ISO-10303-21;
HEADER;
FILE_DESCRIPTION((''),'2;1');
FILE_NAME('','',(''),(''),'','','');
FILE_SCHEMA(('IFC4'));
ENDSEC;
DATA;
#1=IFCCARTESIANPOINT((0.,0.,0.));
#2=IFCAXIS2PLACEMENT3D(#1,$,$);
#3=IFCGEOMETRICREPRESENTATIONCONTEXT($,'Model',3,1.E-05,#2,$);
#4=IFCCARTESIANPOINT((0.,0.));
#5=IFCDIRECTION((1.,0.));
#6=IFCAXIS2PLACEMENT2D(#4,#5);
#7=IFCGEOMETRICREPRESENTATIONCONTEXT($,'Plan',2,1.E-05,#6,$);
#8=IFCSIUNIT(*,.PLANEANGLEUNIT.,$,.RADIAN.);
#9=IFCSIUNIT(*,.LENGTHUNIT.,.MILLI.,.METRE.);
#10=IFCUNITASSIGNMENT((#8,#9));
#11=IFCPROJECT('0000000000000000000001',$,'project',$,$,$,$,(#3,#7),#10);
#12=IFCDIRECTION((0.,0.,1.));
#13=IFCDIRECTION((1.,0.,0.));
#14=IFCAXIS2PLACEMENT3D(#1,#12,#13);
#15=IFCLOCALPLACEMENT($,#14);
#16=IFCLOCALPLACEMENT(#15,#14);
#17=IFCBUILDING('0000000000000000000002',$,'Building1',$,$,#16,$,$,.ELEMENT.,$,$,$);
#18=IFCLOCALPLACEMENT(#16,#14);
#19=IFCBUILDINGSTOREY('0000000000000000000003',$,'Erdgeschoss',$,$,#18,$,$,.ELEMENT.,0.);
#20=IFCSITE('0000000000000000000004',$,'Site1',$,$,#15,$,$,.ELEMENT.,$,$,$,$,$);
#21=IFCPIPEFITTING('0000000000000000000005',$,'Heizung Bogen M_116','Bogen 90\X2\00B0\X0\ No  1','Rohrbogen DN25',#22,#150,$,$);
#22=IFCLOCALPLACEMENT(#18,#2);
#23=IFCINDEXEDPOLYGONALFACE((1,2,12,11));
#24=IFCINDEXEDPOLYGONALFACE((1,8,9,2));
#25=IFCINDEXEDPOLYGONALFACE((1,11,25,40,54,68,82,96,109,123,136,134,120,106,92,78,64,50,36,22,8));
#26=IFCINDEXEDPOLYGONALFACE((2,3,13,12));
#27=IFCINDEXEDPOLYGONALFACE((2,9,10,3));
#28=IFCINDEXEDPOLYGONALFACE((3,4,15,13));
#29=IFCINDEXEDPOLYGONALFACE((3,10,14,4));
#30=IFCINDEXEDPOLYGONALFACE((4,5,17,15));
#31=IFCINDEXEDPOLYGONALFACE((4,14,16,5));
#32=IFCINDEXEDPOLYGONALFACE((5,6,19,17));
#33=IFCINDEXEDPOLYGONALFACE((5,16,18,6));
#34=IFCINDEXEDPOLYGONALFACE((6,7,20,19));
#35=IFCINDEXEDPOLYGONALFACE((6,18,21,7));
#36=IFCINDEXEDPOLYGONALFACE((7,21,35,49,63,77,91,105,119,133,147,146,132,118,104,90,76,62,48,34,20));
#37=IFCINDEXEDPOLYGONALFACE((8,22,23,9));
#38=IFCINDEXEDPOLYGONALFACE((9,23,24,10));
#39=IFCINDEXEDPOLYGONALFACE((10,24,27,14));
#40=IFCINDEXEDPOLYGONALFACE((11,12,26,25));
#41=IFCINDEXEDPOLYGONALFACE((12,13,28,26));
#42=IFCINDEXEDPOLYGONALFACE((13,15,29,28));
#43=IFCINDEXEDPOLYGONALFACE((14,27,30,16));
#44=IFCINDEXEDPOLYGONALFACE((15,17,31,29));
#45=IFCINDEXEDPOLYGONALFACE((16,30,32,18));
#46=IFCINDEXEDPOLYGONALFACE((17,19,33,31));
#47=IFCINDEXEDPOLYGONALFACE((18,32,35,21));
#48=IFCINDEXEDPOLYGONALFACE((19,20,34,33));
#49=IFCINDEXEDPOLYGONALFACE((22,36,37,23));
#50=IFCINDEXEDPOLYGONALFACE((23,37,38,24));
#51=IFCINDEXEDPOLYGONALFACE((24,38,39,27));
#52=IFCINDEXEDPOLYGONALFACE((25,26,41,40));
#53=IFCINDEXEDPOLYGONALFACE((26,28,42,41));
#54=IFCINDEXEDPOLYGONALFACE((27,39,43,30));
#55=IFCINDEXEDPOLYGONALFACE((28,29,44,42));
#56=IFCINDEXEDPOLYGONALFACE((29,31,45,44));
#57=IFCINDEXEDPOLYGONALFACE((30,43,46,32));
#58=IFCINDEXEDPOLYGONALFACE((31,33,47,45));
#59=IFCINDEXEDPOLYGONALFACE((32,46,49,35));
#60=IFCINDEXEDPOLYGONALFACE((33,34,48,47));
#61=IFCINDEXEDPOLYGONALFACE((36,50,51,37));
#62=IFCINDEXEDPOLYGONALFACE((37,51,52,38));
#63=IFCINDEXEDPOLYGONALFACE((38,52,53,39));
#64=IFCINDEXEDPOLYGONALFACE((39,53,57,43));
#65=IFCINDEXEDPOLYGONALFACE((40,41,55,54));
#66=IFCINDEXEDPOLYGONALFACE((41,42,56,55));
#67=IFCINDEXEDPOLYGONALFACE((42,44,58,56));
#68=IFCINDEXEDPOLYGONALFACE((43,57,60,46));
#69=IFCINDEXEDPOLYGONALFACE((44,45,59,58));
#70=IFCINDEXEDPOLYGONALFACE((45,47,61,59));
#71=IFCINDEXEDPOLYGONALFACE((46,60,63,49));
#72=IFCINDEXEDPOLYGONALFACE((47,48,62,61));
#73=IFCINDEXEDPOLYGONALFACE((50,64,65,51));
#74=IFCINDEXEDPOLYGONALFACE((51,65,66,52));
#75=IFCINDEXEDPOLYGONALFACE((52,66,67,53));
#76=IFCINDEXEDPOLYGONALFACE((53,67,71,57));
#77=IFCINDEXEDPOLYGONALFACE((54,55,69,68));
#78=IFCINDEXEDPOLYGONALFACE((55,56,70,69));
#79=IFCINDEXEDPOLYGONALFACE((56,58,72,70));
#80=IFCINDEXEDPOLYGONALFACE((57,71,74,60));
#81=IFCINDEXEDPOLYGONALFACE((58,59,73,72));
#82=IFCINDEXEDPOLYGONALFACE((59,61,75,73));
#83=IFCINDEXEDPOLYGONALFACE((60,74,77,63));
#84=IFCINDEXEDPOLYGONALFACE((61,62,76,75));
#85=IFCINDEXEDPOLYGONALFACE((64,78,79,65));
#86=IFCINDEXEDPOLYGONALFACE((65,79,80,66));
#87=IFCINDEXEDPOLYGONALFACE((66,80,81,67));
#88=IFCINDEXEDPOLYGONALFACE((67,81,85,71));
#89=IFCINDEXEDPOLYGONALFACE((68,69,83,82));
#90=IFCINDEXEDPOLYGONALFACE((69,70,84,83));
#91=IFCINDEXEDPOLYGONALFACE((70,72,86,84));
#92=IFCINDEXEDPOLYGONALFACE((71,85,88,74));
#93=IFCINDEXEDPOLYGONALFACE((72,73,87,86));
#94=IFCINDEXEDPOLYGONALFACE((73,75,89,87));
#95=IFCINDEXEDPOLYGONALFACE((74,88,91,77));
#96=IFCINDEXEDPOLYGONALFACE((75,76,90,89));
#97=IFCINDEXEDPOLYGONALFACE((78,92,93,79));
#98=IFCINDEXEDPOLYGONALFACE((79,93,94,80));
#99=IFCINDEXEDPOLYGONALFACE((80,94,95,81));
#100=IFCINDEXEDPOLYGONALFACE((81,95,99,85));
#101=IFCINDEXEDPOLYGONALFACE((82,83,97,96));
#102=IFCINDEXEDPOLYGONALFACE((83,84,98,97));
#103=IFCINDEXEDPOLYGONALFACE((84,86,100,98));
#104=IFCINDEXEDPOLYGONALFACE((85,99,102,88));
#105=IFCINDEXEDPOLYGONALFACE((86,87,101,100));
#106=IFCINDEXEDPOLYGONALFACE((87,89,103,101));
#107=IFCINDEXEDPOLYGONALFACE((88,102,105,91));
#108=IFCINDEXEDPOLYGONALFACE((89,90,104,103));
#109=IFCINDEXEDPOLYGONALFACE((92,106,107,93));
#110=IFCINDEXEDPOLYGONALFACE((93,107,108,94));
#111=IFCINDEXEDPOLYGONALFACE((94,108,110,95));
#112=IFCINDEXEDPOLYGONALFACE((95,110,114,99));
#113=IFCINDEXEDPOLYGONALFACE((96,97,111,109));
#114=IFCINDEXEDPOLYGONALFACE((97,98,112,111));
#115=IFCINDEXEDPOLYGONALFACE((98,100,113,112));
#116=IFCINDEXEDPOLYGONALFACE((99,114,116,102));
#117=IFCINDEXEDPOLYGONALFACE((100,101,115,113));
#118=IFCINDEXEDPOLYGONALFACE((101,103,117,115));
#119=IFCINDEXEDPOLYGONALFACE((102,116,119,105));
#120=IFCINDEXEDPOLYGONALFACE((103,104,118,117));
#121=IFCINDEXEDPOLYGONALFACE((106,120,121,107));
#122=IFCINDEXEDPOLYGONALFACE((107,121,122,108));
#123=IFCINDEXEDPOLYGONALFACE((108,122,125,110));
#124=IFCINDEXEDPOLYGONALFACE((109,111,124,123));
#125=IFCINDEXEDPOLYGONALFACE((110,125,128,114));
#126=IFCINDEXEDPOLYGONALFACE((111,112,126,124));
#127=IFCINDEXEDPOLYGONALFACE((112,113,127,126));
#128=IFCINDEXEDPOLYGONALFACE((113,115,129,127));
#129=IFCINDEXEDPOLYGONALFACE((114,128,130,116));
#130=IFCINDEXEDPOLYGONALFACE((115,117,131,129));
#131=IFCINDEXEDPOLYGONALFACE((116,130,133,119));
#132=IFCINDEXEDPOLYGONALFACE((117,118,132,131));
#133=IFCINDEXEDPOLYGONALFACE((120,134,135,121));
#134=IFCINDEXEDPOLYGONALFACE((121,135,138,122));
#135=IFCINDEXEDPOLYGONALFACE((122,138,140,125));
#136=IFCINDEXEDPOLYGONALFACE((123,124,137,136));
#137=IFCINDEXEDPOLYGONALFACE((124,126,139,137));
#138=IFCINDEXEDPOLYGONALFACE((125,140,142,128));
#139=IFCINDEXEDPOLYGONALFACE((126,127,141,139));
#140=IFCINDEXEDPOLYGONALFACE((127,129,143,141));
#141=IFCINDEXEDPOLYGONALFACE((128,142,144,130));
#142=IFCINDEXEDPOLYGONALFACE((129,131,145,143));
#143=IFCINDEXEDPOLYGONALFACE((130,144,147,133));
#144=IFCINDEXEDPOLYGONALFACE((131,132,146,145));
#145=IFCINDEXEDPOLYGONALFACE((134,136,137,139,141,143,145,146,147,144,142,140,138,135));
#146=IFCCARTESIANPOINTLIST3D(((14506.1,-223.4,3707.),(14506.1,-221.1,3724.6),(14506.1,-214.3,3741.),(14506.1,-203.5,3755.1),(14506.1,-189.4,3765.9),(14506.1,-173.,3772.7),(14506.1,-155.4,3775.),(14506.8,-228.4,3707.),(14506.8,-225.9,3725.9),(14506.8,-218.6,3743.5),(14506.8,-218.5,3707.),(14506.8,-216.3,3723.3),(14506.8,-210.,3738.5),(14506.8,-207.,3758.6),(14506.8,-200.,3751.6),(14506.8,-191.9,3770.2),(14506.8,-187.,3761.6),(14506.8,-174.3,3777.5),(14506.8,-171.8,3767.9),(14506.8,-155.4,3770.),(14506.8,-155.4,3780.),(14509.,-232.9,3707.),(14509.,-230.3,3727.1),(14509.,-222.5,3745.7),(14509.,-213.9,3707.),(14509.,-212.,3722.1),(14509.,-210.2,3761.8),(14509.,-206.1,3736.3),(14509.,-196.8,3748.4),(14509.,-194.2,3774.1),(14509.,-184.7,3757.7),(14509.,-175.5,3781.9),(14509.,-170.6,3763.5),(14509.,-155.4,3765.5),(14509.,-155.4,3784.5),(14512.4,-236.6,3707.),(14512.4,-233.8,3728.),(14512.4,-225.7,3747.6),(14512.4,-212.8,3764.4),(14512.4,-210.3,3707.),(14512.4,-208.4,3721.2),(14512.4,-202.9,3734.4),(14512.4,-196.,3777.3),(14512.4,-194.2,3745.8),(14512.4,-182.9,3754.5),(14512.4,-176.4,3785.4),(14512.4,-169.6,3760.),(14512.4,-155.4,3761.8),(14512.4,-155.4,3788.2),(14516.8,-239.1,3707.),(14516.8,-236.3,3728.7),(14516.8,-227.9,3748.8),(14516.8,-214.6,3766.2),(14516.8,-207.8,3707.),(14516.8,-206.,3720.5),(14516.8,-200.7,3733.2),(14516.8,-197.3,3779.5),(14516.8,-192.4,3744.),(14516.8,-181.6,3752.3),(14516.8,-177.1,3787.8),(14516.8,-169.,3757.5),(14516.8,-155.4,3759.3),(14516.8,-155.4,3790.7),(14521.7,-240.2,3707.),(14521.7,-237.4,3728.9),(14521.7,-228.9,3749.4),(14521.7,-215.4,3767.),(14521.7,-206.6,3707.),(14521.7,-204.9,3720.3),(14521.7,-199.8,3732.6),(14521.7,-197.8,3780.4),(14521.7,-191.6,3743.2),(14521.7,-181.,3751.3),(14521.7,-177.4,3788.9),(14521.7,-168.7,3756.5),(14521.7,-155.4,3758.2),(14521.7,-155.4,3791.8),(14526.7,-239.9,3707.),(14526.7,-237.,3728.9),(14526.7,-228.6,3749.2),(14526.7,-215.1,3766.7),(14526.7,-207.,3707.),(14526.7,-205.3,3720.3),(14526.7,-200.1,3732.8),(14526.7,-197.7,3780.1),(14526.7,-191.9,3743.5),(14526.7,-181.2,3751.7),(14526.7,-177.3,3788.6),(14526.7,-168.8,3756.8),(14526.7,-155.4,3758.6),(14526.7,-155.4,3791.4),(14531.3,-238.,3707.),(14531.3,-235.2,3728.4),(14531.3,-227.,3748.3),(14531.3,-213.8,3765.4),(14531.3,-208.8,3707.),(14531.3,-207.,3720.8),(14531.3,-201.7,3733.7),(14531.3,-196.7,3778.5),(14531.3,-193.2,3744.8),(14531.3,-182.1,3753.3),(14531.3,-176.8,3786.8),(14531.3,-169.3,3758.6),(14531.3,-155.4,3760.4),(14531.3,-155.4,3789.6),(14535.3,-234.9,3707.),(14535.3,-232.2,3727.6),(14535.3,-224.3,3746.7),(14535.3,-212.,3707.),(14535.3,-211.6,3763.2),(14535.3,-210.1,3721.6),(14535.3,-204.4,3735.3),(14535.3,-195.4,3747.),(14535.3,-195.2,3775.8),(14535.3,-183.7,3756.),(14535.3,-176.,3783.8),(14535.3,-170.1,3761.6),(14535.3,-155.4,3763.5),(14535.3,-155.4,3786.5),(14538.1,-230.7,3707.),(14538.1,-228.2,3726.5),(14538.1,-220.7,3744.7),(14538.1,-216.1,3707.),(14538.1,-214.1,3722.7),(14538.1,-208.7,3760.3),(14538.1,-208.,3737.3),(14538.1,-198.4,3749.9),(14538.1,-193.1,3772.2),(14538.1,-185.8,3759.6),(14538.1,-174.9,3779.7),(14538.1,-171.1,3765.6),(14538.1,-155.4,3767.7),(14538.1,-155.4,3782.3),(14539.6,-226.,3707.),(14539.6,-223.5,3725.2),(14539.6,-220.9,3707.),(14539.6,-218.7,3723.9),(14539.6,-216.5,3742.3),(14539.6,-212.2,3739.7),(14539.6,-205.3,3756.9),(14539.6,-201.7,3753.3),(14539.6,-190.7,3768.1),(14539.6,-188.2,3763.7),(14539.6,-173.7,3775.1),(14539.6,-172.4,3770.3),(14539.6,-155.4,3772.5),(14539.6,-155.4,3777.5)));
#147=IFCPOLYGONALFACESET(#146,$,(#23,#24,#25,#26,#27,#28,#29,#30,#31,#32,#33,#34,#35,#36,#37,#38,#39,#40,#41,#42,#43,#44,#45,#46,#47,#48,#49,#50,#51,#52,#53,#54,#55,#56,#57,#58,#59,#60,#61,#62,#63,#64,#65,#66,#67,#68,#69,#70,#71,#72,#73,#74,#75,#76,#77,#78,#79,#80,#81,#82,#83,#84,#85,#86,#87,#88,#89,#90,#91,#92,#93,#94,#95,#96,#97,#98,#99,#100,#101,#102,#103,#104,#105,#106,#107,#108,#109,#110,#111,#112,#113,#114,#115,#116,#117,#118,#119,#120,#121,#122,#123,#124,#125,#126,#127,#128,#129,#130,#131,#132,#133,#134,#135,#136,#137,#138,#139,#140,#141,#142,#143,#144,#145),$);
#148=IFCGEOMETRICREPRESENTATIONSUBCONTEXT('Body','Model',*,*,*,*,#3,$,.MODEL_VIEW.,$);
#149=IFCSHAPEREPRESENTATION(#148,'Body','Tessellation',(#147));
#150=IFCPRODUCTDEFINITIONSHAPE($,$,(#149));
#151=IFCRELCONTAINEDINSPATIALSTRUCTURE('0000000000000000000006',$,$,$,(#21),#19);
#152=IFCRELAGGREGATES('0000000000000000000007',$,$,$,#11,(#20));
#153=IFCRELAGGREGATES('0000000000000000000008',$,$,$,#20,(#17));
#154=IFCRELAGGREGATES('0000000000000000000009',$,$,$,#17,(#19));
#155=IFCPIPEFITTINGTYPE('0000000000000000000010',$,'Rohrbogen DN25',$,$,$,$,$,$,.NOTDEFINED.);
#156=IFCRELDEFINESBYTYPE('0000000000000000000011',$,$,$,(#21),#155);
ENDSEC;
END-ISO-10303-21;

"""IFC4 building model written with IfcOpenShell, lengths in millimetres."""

from ifc_helpers import new_model, entity, si_unit, frame, origin, origin_with_axes, origin_2d_with_axis, place, context, subcontext, project, spatial, shape, source, transform, mapped, type_object, element, save


model = new_model("IFC4")

# Units and contexts
model_context = context("Model", 3, precision=1e-05, world=origin())
plan_context = context("Plan", 2, precision=1e-05, world=origin_2d_with_axis())
body_context = subcontext(model_context, "Body", "Model", "MODEL_VIEW")
ifc_project = project(units=[si_unit("PLANEANGLEUNIT", "RADIAN"), si_unit("LENGTHUNIT", "METRE", prefix="MILLI")], contexts=[model_context, plan_context])

# Site, building, storey
site_placement = place(None, origin_with_axes())
site = spatial("IfcSite", under=ifc_project, at=site_placement, Name="Site1", CompositionType="ELEMENT")
building_placement = place(site_placement, origin_with_axes())
building = spatial("IfcBuilding", under=site, at=building_placement, Name="Building1", CompositionType="ELEMENT")
storey_placement = place(building_placement, origin_with_axes())
storey = spatial("IfcBuildingStorey", under=building, at=storey_placement, Name="Erdgeschoss", CompositionType="ELEMENT", Elevation=0.0)

# Pipe fitting
pipe_fitting_type = type_object("IfcPipeFittingType", Name="Rohrbogen DN25", PredefinedType="NOTDEFINED")
shared_shape_1 = source(origin_with_axes(), body_context, "Body", "SolidModel", [
    entity("IfcRevolvedAreaSolid", entity("IfcCircleProfileDef", "AREA", None, entity("IfcAxis2Placement2D", entity("IfcCartesianPoint", [0.0, 0.0]), entity("IfcDirection", [1.0, 0.0])), 16.9), entity("IfcAxis2Placement3D", entity("IfcCartesianPoint", [-42.4, 0.0, 25.6]), entity("IfcDirection", [1.0, 0.0, 0.0]), entity("IfcDirection", [0.0, -1.0, 0.0])), entity("IfcAxis1Placement", entity("IfcCartesianPoint", [0.0, 68.0, 0.0]), entity("IfcDirection", [-1.0, 0.0, 0.0])), 1.570796),
])
pipe_fitting_1_placement = place(storey_placement, frame((14522.9, -197.9, 3749.4), z_axis=(0.0, 0.0, 1.0), x_axis=(1.0, 0.0, 0.0)))
element("IfcPipeFitting", 1, at=pipe_fitting_1_placement, inside=storey, type_object=pipe_fitting_type, Name="Heizung Bogen M_116", Description="Bogen 90° No  1", ObjectType="Rohrbogen DN25", shapes=[
    shape(body_context, "Body", "MappedRepresentation", [mapped(shared_shape_1, transform((0.0, 0.0, 0.0), x_axis=(0.0, -1.0, 0.0), y_axis=(1.0, 0.0, 0.0), z_axis=(0.0, 0.0, 1.0), scale=1.0))]),
    shape(body_context, "Body", "MappedRepresentation", [mapped(shared_shape_1, transform((0.0, 0.0, 0.0), x_axis=(0.0, -1.0, 0.0), y_axis=(1.0, 0.0, 0.0), z_axis=(0.0, 0.0, 1.0), scale=1.0))]),
])

save(model, "model.ifc")
